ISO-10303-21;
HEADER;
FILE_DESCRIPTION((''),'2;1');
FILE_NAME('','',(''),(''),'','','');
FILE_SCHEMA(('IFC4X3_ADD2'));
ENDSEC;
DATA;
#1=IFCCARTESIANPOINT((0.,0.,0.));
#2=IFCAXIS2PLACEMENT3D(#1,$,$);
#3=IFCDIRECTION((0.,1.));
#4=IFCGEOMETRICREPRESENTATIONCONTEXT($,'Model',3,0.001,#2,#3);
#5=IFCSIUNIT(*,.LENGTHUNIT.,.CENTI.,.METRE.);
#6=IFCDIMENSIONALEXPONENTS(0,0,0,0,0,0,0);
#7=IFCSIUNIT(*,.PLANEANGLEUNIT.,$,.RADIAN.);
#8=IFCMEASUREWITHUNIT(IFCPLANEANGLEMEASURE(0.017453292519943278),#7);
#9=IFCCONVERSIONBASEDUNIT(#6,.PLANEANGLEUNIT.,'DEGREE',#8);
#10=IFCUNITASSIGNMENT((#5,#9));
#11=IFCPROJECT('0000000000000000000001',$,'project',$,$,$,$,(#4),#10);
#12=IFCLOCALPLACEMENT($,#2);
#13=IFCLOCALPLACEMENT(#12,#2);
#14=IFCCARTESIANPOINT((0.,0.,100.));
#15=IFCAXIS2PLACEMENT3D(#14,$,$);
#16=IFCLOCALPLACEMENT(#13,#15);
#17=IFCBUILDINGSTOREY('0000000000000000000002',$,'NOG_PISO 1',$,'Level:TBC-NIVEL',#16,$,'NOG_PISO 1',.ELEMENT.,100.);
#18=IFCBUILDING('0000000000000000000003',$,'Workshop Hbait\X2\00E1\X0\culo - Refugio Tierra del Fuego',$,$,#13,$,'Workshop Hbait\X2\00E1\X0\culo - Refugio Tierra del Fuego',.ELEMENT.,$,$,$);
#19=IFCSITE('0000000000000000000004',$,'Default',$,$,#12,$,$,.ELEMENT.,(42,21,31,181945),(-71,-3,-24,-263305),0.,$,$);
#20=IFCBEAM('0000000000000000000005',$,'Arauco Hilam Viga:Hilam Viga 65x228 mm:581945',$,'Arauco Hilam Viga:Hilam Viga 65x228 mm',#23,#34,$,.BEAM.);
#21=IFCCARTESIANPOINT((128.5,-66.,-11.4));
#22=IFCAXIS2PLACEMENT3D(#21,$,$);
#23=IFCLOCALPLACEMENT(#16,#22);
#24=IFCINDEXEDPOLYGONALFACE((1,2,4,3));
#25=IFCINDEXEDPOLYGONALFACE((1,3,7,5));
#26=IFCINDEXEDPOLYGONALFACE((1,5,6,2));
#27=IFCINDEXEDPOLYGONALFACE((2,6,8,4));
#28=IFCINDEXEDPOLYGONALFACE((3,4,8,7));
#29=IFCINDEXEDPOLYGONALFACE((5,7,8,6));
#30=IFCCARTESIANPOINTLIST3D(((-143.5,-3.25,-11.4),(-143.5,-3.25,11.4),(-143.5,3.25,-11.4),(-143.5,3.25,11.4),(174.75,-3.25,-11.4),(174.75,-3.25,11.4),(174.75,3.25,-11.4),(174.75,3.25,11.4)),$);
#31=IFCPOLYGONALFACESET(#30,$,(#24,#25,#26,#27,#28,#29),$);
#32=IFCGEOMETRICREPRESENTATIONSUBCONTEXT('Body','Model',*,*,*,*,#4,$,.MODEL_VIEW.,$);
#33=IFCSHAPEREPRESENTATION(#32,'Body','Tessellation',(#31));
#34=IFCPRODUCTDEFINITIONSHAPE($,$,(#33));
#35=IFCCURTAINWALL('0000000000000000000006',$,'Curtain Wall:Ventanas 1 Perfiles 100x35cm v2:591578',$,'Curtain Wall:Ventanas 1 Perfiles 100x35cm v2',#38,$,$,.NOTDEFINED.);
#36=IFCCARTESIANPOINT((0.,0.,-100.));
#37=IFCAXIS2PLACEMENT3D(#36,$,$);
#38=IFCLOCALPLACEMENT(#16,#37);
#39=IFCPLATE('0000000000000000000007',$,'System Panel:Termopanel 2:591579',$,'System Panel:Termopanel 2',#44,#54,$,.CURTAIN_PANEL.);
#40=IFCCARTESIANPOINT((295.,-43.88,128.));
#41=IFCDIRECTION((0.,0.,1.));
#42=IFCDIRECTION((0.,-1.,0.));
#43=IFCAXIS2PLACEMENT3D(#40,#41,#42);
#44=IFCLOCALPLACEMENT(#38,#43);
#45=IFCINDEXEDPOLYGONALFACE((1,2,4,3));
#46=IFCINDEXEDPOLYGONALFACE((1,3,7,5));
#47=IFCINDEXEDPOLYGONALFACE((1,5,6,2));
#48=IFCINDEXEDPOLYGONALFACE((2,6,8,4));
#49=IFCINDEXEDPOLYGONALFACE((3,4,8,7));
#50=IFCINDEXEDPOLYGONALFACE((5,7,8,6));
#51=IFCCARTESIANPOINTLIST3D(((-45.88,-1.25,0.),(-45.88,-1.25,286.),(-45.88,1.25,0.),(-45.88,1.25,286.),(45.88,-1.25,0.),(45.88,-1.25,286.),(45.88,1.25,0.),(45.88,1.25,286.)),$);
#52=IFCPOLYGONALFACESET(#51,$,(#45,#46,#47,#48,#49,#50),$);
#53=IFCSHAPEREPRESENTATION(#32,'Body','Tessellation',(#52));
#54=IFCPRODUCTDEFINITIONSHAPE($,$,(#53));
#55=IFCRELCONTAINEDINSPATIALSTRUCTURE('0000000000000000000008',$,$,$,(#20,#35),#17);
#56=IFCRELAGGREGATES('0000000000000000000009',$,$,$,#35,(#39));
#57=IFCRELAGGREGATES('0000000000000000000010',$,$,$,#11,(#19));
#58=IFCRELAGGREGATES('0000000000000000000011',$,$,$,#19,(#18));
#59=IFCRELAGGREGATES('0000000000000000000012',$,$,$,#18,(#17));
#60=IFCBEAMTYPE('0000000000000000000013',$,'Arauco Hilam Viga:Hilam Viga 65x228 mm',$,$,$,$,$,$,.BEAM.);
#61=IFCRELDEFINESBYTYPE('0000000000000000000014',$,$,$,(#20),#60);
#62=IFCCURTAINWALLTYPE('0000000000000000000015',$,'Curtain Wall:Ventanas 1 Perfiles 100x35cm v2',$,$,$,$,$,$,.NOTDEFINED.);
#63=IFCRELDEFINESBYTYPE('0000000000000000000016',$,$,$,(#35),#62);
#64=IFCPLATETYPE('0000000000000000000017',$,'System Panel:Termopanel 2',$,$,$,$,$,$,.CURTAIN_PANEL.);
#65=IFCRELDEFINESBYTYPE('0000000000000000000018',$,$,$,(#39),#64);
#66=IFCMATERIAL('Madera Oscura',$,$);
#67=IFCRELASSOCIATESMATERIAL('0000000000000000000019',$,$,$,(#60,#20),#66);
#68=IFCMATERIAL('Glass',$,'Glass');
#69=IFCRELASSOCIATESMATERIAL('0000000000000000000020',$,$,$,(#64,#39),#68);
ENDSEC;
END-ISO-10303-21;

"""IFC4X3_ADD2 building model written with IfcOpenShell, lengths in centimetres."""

from ifc_helpers import new_model, entity, si_unit, converted_unit, direction, frame, frame_2d, origin, origin_2d_with_axis, place, context, subcontext, project, spatial, rectangle, extrude, source, transform, mapped, material, material_profile, profile_set, profile_usage, type_object, type_shapes, element, aggregate, save


model = new_model("IFC4X3_ADD2")

# Units and contexts
model_context = context("Model", 3, precision=0.001, world=origin(), true_north=direction((0.0, 1.0)))
body_context = subcontext(model_context, "Body", "Model", "MODEL_VIEW")
ifc_project = project(units=[si_unit("LENGTHUNIT", "METRE", prefix="CENTI"), converted_unit("PLANEANGLEUNIT", "DEGREE", entity("IfcPlaneAngleMeasure", 0.017453292519943278), si_unit("PLANEANGLEUNIT", "RADIAN"), dimensions=[0, 0, 0, 0, 0, 0, 0])], contexts=[model_context])

# Site, building, storey
site_placement = place(None, origin())
site = spatial("IfcSite", under=ifc_project, at=site_placement, Name="Default", CompositionType="ELEMENT", RefLatitude=(42, 21, 31, 181945), RefLongitude=(-71, -3, -24, -263305), RefElevation=0.0)
building_placement = place(site_placement, origin())
building = spatial("IfcBuilding", under=site, at=building_placement, Name="Workshop Hbaitáculo - Refugio Tierra del Fuego", LongName="Workshop Hbaitáculo - Refugio Tierra del Fuego", CompositionType="ELEMENT")
storey_placement = place(building_placement, frame((0.0, 0.0, 100.0)))
storey = spatial("IfcBuildingStorey", under=building, at=storey_placement, Name="NOG_PISO 1", ObjectType="Level:TBC-NIVEL", LongName="NOG_PISO 1", CompositionType="ELEMENT", Elevation=100.0)

# Beam
ifc_material_1 = material(Name="Madera Oscura")
ifc_material_profile_1 = material_profile(ifc_material_1, rectangle(XDim=930.0, YDim=6.5, at=origin_2d_with_axis()), Name="Hilam Viga 65x228 mm")
ifc_profile_set_1 = profile_set([ifc_material_profile_1], Name="Hilam Viga 65x228 mm")
ifc_profile_usage_1 = profile_usage(ifc_profile_set_1, cardinal=8)
beam_type = type_object("IfcBeamType", Name="Arauco Hilam Viga:Hilam Viga 65x228 mm", PredefinedType="BEAM", material=ifc_profile_set_1)
shared_shape_1 = source(origin(), body_context, "Body", "SweptSolid", [
    extrude(rectangle(XDim=318.25, YDim=6.5, at=origin_2d_with_axis()), frame((15.63, 0.0, -11.4), z_axis=(0.0, 0.0, 1.0), x_axis=(-1.0, 0.0, 0.0)), (0.0, 0.0, 1.0), 22.8),
])
type_shapes(beam_type, [shared_shape_1])
beam_placement = place(storey_placement, frame((128.5, -66.0, -11.4)))
element("IfcBeam", 1, at=beam_placement, inside=storey, type_object=beam_type, material=ifc_profile_usage_1, Name="Arauco Hilam Viga:Hilam Viga 65x228 mm:581945", ObjectType="Arauco Hilam Viga:Hilam Viga 65x228 mm", PredefinedType="BEAM", context=body_context, shape_type="MappedRepresentation", body=[
    mapped(shared_shape_1, transform((0.0, 0.0, 0.0), scale=1.0)),
])

# Curtain wall
curtain_wall_type = type_object("IfcCurtainWallType", Name="Curtain Wall:Ventanas 1 Perfiles 100x35cm v2", PredefinedType="NOTDEFINED")
curtain_wall_1_placement = place(storey_placement, frame((0.0, 0.0, -100.0)))
curtain_wall_1 = element("IfcCurtainWall", 2, at=curtain_wall_1_placement, inside=storey, type_object=curtain_wall_type, Name="Curtain Wall:Ventanas 1 Perfiles 100x35cm v2:591578", ObjectType="Curtain Wall:Ventanas 1 Perfiles 100x35cm v2", PredefinedType="NOTDEFINED")

# Plate
ifc_material_2 = material(Name="Glass", Category="Glass")
plate_type = type_object("IfcPlateType", Name="System Panel:Termopanel 2", PredefinedType="CURTAIN_PANEL", material=ifc_material_2)
shared_shape_2 = source(origin(), body_context, "Body", "SweptSolid", [
    extrude(rectangle(XDim=2.5, YDim=91.75, at=frame_2d((0.0, 0.0), x_axis=(1.0, 0.0))), frame((0.0, 0.0, 0.0), z_axis=(0.0, 0.0, 1.0), x_axis=(0.0, 1.0, 0.0)), (0.0, 0.0, 1.0), 286.0),
])
type_shapes(plate_type, [shared_shape_2])
plate_placement = place(curtain_wall_1_placement, frame((295.0, -43.88, 128.0), z_axis=(0.0, 0.0, 1.0), x_axis=(0.0, -1.0, 0.0)))
plate = element("IfcPlate", 3, at=plate_placement, type_object=plate_type, material=ifc_material_2, Name="System Panel:Termopanel 2:591579", ObjectType="System Panel:Termopanel 2", PredefinedType="CURTAIN_PANEL", context=body_context, shape_type="MappedRepresentation", body=[
    mapped(shared_shape_2, transform((0.0, 0.0, 0.0), scale=1.0)),
])
aggregate(curtain_wall_1, [plate])

save(model, "model.ifc")
